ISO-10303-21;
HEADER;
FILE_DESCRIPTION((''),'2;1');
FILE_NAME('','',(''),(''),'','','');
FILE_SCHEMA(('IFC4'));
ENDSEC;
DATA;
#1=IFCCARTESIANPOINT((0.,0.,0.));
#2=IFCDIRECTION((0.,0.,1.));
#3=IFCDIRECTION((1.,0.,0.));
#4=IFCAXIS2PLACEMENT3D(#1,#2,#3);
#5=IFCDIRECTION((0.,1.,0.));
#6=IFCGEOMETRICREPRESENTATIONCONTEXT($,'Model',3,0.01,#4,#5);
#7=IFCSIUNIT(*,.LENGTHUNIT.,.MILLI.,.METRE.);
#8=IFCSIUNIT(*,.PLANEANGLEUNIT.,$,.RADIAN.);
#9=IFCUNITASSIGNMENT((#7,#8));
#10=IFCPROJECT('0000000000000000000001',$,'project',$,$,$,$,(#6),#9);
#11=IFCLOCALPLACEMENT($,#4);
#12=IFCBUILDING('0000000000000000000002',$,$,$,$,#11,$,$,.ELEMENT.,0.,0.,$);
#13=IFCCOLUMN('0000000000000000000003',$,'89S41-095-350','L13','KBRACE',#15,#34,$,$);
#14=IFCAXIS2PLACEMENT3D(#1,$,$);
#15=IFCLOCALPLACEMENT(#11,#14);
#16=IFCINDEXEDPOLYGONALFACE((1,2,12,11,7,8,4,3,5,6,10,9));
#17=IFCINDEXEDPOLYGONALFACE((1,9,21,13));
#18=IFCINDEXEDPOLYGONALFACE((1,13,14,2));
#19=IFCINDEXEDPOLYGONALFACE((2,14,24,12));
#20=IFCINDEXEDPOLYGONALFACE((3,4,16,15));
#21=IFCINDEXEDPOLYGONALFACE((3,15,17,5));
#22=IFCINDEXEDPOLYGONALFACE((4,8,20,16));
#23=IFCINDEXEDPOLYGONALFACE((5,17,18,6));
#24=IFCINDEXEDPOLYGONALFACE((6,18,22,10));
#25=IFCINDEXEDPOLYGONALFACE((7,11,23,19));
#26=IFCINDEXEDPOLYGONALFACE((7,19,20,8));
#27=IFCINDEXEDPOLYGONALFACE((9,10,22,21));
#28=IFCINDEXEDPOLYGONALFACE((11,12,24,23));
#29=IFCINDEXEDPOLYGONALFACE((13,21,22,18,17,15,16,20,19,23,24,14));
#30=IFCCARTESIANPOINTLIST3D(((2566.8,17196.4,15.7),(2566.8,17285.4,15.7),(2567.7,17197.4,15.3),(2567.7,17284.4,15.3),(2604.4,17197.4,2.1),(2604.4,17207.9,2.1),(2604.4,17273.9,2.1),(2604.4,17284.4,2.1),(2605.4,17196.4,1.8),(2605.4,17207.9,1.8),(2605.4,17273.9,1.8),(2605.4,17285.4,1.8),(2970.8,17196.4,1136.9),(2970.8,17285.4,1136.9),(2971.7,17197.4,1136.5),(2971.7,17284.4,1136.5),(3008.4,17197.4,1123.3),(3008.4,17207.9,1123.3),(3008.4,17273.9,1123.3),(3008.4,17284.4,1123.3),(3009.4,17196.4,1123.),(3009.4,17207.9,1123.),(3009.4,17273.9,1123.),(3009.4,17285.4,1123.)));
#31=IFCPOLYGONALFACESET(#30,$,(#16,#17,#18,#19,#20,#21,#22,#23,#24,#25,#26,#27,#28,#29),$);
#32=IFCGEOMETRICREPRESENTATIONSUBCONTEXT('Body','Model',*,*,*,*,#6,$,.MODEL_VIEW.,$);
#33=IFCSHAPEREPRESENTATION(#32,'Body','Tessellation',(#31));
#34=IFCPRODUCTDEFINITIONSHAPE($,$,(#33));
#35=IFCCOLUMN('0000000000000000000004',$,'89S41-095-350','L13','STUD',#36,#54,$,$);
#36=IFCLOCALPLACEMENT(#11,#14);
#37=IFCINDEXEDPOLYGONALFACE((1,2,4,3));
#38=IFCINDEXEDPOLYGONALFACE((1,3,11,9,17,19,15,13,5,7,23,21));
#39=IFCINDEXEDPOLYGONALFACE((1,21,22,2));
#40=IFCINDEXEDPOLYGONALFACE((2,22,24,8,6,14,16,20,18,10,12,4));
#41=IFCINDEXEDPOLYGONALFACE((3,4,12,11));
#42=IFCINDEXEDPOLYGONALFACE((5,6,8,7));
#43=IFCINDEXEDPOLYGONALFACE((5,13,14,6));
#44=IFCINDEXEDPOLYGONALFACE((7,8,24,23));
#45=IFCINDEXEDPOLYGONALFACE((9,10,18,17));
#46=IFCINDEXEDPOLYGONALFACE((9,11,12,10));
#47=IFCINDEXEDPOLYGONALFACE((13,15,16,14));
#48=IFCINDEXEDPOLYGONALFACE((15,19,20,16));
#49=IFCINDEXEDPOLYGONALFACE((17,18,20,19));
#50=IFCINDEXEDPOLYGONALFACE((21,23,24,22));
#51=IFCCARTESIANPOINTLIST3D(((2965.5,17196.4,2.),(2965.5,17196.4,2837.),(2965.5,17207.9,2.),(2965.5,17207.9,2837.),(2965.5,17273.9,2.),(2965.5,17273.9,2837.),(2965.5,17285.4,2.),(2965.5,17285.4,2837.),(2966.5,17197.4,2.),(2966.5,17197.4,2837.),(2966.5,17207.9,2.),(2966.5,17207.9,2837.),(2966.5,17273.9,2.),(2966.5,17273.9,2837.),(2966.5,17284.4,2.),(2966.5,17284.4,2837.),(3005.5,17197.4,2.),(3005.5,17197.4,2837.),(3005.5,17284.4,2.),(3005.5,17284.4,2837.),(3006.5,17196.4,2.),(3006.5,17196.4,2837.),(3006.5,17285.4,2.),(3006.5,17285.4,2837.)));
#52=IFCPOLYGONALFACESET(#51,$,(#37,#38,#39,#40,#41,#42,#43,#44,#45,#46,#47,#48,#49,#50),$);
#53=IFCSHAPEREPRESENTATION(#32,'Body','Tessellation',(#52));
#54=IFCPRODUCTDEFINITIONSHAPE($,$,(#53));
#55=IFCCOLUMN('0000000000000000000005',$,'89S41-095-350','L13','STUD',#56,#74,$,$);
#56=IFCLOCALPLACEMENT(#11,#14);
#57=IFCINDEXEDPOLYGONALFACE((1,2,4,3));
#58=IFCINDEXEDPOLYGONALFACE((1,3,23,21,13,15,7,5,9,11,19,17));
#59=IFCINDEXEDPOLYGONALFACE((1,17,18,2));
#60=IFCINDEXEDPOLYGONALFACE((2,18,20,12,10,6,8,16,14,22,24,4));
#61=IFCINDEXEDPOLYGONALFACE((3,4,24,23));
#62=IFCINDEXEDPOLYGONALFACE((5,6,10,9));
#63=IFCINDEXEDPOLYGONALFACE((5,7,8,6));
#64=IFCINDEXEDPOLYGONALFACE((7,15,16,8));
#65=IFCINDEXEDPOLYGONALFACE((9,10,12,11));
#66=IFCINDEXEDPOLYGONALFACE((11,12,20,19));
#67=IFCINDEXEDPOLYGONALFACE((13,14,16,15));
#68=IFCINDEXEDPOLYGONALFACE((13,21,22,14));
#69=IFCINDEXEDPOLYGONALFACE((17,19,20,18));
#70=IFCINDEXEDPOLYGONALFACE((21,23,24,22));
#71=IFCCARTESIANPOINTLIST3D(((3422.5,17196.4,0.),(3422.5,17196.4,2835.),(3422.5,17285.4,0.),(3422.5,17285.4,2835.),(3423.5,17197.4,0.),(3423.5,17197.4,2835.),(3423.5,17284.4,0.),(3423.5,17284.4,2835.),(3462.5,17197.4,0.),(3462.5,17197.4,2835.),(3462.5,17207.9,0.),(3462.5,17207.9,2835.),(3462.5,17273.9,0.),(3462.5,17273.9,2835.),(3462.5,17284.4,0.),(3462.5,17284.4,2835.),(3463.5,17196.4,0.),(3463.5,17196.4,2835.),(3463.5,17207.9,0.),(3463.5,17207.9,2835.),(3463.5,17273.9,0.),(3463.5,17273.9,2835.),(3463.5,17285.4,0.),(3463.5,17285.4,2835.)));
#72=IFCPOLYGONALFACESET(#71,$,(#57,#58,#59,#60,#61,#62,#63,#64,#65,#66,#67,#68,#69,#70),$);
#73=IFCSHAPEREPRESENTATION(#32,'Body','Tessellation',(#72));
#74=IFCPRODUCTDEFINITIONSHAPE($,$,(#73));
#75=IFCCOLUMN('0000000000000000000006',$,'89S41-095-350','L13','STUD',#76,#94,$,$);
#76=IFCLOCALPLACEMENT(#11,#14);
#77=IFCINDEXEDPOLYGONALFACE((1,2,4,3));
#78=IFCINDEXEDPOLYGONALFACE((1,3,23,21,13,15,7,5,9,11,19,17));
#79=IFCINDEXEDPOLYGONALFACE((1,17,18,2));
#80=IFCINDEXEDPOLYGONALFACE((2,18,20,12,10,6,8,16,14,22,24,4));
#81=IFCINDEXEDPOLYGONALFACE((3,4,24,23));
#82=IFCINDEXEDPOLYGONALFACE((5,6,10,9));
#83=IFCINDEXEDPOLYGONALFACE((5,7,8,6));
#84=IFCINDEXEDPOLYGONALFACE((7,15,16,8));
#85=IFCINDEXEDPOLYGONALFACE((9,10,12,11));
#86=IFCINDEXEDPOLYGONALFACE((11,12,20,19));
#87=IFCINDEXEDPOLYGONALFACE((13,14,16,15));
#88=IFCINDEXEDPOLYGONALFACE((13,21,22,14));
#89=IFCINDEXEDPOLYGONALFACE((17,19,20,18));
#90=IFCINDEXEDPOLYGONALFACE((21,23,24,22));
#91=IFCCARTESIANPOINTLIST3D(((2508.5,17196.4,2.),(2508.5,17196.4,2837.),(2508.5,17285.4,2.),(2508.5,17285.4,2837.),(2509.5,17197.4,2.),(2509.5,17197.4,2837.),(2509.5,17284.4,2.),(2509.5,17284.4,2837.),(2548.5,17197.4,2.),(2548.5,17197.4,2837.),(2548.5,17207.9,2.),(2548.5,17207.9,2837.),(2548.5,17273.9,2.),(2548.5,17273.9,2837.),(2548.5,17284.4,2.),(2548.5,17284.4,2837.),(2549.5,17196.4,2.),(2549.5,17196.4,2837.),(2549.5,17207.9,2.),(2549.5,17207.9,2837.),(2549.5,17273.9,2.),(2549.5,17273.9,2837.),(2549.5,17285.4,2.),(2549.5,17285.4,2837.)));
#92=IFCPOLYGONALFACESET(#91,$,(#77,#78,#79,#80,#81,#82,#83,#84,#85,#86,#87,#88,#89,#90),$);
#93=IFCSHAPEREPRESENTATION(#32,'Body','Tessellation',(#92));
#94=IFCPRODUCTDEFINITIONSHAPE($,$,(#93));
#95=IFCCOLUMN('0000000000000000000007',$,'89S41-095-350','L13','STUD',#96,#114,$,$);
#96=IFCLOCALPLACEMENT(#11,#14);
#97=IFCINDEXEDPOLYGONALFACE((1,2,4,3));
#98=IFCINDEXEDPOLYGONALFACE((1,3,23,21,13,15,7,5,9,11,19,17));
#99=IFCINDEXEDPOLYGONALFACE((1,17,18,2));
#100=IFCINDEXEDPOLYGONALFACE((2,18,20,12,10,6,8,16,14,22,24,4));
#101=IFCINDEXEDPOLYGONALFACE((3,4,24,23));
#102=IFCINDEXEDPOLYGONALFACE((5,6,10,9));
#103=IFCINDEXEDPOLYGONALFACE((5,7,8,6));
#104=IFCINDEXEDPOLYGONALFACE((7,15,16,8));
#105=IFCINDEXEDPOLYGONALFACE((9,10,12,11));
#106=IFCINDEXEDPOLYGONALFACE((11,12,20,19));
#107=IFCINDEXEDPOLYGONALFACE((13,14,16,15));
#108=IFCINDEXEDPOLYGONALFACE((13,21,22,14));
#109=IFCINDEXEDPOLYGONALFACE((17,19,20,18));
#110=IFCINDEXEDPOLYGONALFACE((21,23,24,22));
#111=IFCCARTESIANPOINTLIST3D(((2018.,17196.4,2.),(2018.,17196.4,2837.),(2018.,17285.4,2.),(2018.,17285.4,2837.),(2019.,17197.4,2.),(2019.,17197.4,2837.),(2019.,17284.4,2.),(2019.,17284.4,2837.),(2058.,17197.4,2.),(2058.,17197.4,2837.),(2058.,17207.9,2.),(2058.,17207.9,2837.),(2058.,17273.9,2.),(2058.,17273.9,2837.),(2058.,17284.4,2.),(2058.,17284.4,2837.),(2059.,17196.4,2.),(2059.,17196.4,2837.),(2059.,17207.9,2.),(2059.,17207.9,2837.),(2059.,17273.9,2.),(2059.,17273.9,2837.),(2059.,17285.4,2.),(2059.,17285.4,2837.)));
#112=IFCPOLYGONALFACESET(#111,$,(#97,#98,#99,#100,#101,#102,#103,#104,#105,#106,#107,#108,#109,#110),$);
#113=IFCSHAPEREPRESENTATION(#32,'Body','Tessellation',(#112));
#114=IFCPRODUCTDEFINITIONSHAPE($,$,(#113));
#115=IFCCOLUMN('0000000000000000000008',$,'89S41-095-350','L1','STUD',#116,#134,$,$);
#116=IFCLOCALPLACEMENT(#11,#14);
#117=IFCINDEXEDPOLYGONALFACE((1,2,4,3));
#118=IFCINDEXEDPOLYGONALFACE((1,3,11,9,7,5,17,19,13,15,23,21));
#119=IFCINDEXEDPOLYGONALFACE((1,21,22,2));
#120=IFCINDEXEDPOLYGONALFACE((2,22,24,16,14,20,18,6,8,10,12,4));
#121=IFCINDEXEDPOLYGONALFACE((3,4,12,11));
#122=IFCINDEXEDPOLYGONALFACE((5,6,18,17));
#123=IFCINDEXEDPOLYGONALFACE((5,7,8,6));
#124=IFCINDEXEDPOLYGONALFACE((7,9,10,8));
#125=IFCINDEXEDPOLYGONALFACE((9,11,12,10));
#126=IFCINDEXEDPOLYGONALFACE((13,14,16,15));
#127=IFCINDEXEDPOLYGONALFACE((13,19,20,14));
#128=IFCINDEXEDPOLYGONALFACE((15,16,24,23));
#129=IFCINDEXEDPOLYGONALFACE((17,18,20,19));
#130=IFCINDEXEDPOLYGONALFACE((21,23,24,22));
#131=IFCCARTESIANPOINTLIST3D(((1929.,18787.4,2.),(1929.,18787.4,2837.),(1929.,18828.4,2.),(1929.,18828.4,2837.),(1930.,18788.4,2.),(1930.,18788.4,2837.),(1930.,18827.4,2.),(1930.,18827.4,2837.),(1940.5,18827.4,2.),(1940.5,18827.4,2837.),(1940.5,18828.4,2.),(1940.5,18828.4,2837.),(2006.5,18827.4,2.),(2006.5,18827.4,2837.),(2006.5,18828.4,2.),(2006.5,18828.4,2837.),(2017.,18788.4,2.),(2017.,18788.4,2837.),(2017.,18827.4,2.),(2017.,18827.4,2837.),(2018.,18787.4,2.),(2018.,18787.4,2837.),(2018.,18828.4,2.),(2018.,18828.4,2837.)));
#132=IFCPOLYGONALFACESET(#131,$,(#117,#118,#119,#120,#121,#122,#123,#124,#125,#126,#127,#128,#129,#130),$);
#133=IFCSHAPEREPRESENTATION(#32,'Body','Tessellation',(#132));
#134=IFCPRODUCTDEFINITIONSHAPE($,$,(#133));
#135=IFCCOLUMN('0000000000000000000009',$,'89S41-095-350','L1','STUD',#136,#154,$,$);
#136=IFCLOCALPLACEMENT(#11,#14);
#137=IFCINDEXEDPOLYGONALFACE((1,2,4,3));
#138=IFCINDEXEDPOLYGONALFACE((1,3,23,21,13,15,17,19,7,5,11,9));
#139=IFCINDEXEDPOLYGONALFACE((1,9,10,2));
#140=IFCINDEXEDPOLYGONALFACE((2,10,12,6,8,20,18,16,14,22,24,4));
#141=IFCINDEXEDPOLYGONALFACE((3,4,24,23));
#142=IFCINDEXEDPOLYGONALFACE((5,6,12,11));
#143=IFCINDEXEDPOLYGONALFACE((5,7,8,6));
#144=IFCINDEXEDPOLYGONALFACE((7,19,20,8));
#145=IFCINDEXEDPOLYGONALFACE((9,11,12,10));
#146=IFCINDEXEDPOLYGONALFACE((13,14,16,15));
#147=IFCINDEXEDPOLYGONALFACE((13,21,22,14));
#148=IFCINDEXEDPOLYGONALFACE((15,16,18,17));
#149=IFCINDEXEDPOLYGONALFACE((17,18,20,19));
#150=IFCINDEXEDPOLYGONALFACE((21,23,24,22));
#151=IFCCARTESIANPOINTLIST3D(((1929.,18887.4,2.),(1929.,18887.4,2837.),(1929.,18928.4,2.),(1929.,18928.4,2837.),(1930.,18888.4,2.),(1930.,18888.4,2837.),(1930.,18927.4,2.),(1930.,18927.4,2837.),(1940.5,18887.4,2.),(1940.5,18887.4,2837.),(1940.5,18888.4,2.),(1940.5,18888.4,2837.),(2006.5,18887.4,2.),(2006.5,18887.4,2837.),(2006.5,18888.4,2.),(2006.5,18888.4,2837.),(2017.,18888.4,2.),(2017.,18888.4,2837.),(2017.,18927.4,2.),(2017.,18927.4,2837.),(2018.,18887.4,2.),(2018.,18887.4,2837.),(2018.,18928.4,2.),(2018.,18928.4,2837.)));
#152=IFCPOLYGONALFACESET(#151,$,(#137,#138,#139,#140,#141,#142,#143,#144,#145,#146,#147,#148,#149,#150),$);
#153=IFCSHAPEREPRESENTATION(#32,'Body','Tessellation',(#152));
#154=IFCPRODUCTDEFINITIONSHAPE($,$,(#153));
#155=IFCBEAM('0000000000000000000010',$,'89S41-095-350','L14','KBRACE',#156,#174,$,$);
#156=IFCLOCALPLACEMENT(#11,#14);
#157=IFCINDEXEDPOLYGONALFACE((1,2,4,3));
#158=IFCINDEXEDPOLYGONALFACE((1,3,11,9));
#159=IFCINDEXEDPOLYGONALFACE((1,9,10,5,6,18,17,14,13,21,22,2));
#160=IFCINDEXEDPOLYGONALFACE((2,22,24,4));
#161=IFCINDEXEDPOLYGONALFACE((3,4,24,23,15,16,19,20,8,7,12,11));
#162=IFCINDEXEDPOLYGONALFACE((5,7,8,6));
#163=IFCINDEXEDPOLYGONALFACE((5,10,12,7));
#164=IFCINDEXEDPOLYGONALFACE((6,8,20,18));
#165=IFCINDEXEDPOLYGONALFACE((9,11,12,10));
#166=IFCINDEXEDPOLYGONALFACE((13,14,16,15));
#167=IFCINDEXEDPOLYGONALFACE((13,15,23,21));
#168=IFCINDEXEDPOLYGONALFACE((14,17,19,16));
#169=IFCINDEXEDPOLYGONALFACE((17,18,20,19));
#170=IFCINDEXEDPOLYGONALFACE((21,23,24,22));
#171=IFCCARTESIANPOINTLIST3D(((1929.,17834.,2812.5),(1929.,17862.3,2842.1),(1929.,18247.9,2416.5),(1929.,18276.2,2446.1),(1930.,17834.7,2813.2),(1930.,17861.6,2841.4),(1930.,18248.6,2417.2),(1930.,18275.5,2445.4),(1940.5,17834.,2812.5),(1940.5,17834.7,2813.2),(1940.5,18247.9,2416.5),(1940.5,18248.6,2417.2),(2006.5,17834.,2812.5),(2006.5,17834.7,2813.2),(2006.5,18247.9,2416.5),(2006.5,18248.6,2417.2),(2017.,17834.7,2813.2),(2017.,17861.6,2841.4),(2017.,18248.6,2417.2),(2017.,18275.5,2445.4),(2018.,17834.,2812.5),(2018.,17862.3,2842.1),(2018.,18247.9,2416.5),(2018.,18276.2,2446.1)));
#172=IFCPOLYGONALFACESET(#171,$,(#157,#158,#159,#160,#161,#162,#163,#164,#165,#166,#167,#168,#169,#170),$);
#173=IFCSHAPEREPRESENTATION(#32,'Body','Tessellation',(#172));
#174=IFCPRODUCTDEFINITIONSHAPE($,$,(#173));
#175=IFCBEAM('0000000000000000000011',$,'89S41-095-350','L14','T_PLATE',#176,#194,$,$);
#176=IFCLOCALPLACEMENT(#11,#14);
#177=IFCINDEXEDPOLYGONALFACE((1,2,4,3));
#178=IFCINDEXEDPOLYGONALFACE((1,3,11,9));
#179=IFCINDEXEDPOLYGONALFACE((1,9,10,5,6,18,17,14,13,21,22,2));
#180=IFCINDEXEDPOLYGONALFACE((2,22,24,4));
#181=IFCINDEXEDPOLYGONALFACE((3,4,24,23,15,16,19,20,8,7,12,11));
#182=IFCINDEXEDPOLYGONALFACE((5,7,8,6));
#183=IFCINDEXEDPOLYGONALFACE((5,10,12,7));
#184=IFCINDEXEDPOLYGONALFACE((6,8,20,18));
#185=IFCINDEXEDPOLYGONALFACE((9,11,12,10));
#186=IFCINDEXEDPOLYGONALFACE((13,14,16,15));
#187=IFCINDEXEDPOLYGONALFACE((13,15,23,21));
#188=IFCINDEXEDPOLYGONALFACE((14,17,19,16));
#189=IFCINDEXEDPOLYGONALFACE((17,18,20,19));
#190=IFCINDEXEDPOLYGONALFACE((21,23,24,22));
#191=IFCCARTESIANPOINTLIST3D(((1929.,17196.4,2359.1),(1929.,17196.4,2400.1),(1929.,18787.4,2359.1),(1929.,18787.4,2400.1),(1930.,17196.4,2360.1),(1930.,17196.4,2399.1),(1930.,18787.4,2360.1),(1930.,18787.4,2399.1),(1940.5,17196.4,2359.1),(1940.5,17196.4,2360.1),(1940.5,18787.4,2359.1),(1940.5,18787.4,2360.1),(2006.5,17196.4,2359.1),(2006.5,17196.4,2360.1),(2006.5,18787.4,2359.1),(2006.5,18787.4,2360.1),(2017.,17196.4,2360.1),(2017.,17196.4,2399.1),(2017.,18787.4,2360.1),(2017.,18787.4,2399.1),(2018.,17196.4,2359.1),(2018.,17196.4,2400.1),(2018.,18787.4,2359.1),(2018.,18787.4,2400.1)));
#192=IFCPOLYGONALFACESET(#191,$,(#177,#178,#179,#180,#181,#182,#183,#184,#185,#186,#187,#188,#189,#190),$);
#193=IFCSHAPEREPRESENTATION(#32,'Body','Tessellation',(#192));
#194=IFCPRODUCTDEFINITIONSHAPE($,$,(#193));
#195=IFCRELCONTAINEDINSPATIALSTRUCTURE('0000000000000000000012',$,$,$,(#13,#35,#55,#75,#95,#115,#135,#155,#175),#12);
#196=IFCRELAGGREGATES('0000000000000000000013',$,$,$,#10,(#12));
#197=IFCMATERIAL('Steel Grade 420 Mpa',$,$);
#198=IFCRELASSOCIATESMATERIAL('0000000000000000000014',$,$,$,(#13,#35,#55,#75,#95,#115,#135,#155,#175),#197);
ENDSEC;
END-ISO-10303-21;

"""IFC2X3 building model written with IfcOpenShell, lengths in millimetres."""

from ifc_helpers import new_model, si_unit, direction, frame, origin, origin_with_axes, origin_2d_with_axis, place, context, subcontext, project, spatial, c_section, extrude, source, transform, mapped, material, element, save


model = new_model("IFC2X3")

# Units and contexts
model_context = context("Model", 3, precision=0.01, world=origin_with_axes(), true_north=direction((0.0, 1.0, 0.0)))
body_context = subcontext(model_context, "Body", "Model", "MODEL_VIEW")
ifc_project = project(units=[si_unit("LENGTHUNIT", "METRE", prefix="MILLI"), si_unit("PLANEANGLEUNIT", "RADIAN")], contexts=[model_context])

# Building
building_placement = place(None, origin_with_axes())
building = spatial("IfcBuilding", under=ifc_project, at=building_placement, CompositionType="ELEMENT", ElevationOfRefHeight=0.0, ElevationOfTerrain=0.0)

# Columns
ifc_material_1 = material(Name="Steel Grade 420 Mpa")
shared_shape_1 = source(origin(), body_context, "Body", "SweptSolid", [
    extrude(c_section(Depth=89.0, Width=41.0, WallThickness=1.0, Girth=11.5, at=origin_2d_with_axis()), origin_with_axes(), (0.0, 0.0, 1.0), 1191.8),
])
column_1_placement = place(None, frame((2586.1, 17240.9, 8.7), z_axis=(0.338991, 0.0, 0.94079), x_axis=(0.94079, 0.0, -0.338991)))
element("IfcColumn", 1, at=column_1_placement, inside=building, material=ifc_material_1, Name="89S41-095-350", Description="L13", ObjectType="KBRACE", context=body_context, shape_type="MappedRepresentation", body=[
    mapped(shared_shape_1, transform((0.0, 0.0, 0.0), scale=1.0)),
])
shared_shape_2 = source(origin(), body_context, "Body", "SweptSolid", [
    extrude(c_section(Depth=89.0, Width=41.0, WallThickness=1.0, Girth=11.5, at=origin_2d_with_axis()), origin_with_axes(), (0.0, 0.0, 1.0), 2835.0),
])
column_2_placement = place(None, frame((2986.0, 17240.9, 2.0), z_axis=(0.0, 0.0, 1.0), x_axis=(-1.0, 0.0, 0.0)))
element("IfcColumn", 2, at=column_2_placement, inside=building, material=ifc_material_1, Name="89S41-095-350", Description="L13", ObjectType="STUD", context=body_context, shape_type="MappedRepresentation", body=[
    mapped(shared_shape_2, transform((0.0, 0.0, 0.0), scale=1.0)),
])
shared_shape_3 = source(origin(), body_context, "Body", "SweptSolid", [
    extrude(c_section(Depth=89.0, Width=41.0, WallThickness=1.0, Girth=11.5, at=origin_2d_with_axis()), origin_with_axes(), (0.0, 0.0, 1.0), 2835.0),
])
column_3_placement = place(None, frame((3443.0, 17240.9, 0.0), z_axis=(0.0, 0.0, 1.0), x_axis=(1.0, 0.0, 0.0)))
element("IfcColumn", 3, at=column_3_placement, inside=building, material=ifc_material_1, Name="89S41-095-350", Description="L13", ObjectType="STUD", context=body_context, shape_type="MappedRepresentation", body=[
    mapped(shared_shape_3, transform((0.0, 0.0, 0.0), scale=1.0)),
])
shared_shape_4 = source(origin(), body_context, "Body", "SweptSolid", [
    extrude(c_section(Depth=89.0, Width=41.0, WallThickness=1.0, Girth=11.5, at=origin_2d_with_axis()), origin_with_axes(), (0.0, 0.0, 1.0), 2835.0),
])
column_4_placement = place(None, frame((2529.0, 17240.9, 2.0), z_axis=(0.0, 0.0, 1.0), x_axis=(1.0, 0.0, 0.0)))
element("IfcColumn", 4, at=column_4_placement, inside=building, material=ifc_material_1, Name="89S41-095-350", Description="L13", ObjectType="STUD", context=body_context, shape_type="MappedRepresentation", body=[
    mapped(shared_shape_4, transform((0.0, 0.0, 0.0), scale=1.0)),
])
shared_shape_5 = source(origin(), body_context, "Body", "SweptSolid", [
    extrude(c_section(Depth=89.0, Width=41.0, WallThickness=1.0, Girth=11.5, at=origin_2d_with_axis()), origin_with_axes(), (0.0, 0.0, 1.0), 2835.0),
])
column_5_placement = place(None, frame((2038.5, 17240.9, 2.0), z_axis=(0.0, 0.0, 1.0), x_axis=(1.0, 0.0, 0.0)))
element("IfcColumn", 5, at=column_5_placement, inside=building, material=ifc_material_1, Name="89S41-095-350", Description="L13", ObjectType="STUD", context=body_context, shape_type="MappedRepresentation", body=[
    mapped(shared_shape_5, transform((0.0, 0.0, 0.0), scale=1.0)),
])
shared_shape_6 = source(origin(), body_context, "Body", "SweptSolid", [
    extrude(c_section(Depth=89.0, Width=41.0, WallThickness=1.0, Girth=11.5, at=origin_2d_with_axis()), origin_with_axes(), (0.0, 0.0, 1.0), 2835.0),
])
column_6_placement = place(None, frame((1973.5, 18807.9, 2.0), z_axis=(0.0, 0.0, 1.0), x_axis=(0.0, 1.0, 0.0)))
element("IfcColumn", 6, at=column_6_placement, inside=building, material=ifc_material_1, Name="89S41-095-350", Description="L1", ObjectType="STUD", context=body_context, shape_type="MappedRepresentation", body=[
    mapped(shared_shape_6, transform((0.0, 0.0, 0.0), scale=1.0)),
])
shared_shape_7 = source(origin(), body_context, "Body", "SweptSolid", [
    extrude(c_section(Depth=89.0, Width=41.0, WallThickness=1.0, Girth=11.5, at=origin_2d_with_axis()), origin_with_axes(), (0.0, 0.0, 1.0), 2835.0),
])
column_7_placement = place(None, frame((1973.5, 18907.9, 2.0), z_axis=(0.0, 0.0, 1.0), x_axis=(0.0, -1.0, 0.0)))
element("IfcColumn", 7, at=column_7_placement, inside=building, material=ifc_material_1, Name="89S41-095-350", Description="L1", ObjectType="STUD", context=body_context, shape_type="MappedRepresentation", body=[
    mapped(shared_shape_7, transform((0.0, 0.0, 0.0), scale=1.0)),
])

# Beams
shared_shape_8 = source(origin(), body_context, "Body", "SweptSolid", [
    extrude(c_section(Depth=89.0, Width=41.0, WallThickness=1.0, Girth=11.5, at=origin_2d_with_axis()), origin_with_axes(), (0.0, 0.0, 1.0), 572.8),
])
beam_1_placement = place(None, frame((1973.5, 18262.0, 2431.3), z_axis=(0.0, -0.72257, 0.691297), x_axis=(0.0, -0.691297, -0.72257)))
element("IfcBeam", 8, at=beam_1_placement, inside=building, material=ifc_material_1, Name="89S41-095-350", Description="L14", ObjectType="KBRACE", context=body_context, shape_type="MappedRepresentation", body=[
    mapped(shared_shape_8, transform((0.0, 0.0, 0.0), scale=1.0)),
])
shared_shape_9 = source(origin(), body_context, "Body", "SweptSolid", [
    extrude(c_section(Depth=89.0, Width=41.0, WallThickness=1.0, Girth=11.5, at=origin_2d_with_axis()), origin_with_axes(), (0.0, 0.0, 1.0), 1591.0),
])
beam_2_placement = place(None, frame((1973.5, 18787.4, 2379.6), z_axis=(0.0, -1.0, 0.0), x_axis=(0.0, 0.0, -1.0)))
element("IfcBeam", 9, at=beam_2_placement, inside=building, material=ifc_material_1, Name="89S41-095-350", Description="L14", ObjectType="T_PLATE", context=body_context, shape_type="MappedRepresentation", body=[
    mapped(shared_shape_9, transform((0.0, 0.0, 0.0), scale=1.0)),
])

save(model, "model.ifc")
